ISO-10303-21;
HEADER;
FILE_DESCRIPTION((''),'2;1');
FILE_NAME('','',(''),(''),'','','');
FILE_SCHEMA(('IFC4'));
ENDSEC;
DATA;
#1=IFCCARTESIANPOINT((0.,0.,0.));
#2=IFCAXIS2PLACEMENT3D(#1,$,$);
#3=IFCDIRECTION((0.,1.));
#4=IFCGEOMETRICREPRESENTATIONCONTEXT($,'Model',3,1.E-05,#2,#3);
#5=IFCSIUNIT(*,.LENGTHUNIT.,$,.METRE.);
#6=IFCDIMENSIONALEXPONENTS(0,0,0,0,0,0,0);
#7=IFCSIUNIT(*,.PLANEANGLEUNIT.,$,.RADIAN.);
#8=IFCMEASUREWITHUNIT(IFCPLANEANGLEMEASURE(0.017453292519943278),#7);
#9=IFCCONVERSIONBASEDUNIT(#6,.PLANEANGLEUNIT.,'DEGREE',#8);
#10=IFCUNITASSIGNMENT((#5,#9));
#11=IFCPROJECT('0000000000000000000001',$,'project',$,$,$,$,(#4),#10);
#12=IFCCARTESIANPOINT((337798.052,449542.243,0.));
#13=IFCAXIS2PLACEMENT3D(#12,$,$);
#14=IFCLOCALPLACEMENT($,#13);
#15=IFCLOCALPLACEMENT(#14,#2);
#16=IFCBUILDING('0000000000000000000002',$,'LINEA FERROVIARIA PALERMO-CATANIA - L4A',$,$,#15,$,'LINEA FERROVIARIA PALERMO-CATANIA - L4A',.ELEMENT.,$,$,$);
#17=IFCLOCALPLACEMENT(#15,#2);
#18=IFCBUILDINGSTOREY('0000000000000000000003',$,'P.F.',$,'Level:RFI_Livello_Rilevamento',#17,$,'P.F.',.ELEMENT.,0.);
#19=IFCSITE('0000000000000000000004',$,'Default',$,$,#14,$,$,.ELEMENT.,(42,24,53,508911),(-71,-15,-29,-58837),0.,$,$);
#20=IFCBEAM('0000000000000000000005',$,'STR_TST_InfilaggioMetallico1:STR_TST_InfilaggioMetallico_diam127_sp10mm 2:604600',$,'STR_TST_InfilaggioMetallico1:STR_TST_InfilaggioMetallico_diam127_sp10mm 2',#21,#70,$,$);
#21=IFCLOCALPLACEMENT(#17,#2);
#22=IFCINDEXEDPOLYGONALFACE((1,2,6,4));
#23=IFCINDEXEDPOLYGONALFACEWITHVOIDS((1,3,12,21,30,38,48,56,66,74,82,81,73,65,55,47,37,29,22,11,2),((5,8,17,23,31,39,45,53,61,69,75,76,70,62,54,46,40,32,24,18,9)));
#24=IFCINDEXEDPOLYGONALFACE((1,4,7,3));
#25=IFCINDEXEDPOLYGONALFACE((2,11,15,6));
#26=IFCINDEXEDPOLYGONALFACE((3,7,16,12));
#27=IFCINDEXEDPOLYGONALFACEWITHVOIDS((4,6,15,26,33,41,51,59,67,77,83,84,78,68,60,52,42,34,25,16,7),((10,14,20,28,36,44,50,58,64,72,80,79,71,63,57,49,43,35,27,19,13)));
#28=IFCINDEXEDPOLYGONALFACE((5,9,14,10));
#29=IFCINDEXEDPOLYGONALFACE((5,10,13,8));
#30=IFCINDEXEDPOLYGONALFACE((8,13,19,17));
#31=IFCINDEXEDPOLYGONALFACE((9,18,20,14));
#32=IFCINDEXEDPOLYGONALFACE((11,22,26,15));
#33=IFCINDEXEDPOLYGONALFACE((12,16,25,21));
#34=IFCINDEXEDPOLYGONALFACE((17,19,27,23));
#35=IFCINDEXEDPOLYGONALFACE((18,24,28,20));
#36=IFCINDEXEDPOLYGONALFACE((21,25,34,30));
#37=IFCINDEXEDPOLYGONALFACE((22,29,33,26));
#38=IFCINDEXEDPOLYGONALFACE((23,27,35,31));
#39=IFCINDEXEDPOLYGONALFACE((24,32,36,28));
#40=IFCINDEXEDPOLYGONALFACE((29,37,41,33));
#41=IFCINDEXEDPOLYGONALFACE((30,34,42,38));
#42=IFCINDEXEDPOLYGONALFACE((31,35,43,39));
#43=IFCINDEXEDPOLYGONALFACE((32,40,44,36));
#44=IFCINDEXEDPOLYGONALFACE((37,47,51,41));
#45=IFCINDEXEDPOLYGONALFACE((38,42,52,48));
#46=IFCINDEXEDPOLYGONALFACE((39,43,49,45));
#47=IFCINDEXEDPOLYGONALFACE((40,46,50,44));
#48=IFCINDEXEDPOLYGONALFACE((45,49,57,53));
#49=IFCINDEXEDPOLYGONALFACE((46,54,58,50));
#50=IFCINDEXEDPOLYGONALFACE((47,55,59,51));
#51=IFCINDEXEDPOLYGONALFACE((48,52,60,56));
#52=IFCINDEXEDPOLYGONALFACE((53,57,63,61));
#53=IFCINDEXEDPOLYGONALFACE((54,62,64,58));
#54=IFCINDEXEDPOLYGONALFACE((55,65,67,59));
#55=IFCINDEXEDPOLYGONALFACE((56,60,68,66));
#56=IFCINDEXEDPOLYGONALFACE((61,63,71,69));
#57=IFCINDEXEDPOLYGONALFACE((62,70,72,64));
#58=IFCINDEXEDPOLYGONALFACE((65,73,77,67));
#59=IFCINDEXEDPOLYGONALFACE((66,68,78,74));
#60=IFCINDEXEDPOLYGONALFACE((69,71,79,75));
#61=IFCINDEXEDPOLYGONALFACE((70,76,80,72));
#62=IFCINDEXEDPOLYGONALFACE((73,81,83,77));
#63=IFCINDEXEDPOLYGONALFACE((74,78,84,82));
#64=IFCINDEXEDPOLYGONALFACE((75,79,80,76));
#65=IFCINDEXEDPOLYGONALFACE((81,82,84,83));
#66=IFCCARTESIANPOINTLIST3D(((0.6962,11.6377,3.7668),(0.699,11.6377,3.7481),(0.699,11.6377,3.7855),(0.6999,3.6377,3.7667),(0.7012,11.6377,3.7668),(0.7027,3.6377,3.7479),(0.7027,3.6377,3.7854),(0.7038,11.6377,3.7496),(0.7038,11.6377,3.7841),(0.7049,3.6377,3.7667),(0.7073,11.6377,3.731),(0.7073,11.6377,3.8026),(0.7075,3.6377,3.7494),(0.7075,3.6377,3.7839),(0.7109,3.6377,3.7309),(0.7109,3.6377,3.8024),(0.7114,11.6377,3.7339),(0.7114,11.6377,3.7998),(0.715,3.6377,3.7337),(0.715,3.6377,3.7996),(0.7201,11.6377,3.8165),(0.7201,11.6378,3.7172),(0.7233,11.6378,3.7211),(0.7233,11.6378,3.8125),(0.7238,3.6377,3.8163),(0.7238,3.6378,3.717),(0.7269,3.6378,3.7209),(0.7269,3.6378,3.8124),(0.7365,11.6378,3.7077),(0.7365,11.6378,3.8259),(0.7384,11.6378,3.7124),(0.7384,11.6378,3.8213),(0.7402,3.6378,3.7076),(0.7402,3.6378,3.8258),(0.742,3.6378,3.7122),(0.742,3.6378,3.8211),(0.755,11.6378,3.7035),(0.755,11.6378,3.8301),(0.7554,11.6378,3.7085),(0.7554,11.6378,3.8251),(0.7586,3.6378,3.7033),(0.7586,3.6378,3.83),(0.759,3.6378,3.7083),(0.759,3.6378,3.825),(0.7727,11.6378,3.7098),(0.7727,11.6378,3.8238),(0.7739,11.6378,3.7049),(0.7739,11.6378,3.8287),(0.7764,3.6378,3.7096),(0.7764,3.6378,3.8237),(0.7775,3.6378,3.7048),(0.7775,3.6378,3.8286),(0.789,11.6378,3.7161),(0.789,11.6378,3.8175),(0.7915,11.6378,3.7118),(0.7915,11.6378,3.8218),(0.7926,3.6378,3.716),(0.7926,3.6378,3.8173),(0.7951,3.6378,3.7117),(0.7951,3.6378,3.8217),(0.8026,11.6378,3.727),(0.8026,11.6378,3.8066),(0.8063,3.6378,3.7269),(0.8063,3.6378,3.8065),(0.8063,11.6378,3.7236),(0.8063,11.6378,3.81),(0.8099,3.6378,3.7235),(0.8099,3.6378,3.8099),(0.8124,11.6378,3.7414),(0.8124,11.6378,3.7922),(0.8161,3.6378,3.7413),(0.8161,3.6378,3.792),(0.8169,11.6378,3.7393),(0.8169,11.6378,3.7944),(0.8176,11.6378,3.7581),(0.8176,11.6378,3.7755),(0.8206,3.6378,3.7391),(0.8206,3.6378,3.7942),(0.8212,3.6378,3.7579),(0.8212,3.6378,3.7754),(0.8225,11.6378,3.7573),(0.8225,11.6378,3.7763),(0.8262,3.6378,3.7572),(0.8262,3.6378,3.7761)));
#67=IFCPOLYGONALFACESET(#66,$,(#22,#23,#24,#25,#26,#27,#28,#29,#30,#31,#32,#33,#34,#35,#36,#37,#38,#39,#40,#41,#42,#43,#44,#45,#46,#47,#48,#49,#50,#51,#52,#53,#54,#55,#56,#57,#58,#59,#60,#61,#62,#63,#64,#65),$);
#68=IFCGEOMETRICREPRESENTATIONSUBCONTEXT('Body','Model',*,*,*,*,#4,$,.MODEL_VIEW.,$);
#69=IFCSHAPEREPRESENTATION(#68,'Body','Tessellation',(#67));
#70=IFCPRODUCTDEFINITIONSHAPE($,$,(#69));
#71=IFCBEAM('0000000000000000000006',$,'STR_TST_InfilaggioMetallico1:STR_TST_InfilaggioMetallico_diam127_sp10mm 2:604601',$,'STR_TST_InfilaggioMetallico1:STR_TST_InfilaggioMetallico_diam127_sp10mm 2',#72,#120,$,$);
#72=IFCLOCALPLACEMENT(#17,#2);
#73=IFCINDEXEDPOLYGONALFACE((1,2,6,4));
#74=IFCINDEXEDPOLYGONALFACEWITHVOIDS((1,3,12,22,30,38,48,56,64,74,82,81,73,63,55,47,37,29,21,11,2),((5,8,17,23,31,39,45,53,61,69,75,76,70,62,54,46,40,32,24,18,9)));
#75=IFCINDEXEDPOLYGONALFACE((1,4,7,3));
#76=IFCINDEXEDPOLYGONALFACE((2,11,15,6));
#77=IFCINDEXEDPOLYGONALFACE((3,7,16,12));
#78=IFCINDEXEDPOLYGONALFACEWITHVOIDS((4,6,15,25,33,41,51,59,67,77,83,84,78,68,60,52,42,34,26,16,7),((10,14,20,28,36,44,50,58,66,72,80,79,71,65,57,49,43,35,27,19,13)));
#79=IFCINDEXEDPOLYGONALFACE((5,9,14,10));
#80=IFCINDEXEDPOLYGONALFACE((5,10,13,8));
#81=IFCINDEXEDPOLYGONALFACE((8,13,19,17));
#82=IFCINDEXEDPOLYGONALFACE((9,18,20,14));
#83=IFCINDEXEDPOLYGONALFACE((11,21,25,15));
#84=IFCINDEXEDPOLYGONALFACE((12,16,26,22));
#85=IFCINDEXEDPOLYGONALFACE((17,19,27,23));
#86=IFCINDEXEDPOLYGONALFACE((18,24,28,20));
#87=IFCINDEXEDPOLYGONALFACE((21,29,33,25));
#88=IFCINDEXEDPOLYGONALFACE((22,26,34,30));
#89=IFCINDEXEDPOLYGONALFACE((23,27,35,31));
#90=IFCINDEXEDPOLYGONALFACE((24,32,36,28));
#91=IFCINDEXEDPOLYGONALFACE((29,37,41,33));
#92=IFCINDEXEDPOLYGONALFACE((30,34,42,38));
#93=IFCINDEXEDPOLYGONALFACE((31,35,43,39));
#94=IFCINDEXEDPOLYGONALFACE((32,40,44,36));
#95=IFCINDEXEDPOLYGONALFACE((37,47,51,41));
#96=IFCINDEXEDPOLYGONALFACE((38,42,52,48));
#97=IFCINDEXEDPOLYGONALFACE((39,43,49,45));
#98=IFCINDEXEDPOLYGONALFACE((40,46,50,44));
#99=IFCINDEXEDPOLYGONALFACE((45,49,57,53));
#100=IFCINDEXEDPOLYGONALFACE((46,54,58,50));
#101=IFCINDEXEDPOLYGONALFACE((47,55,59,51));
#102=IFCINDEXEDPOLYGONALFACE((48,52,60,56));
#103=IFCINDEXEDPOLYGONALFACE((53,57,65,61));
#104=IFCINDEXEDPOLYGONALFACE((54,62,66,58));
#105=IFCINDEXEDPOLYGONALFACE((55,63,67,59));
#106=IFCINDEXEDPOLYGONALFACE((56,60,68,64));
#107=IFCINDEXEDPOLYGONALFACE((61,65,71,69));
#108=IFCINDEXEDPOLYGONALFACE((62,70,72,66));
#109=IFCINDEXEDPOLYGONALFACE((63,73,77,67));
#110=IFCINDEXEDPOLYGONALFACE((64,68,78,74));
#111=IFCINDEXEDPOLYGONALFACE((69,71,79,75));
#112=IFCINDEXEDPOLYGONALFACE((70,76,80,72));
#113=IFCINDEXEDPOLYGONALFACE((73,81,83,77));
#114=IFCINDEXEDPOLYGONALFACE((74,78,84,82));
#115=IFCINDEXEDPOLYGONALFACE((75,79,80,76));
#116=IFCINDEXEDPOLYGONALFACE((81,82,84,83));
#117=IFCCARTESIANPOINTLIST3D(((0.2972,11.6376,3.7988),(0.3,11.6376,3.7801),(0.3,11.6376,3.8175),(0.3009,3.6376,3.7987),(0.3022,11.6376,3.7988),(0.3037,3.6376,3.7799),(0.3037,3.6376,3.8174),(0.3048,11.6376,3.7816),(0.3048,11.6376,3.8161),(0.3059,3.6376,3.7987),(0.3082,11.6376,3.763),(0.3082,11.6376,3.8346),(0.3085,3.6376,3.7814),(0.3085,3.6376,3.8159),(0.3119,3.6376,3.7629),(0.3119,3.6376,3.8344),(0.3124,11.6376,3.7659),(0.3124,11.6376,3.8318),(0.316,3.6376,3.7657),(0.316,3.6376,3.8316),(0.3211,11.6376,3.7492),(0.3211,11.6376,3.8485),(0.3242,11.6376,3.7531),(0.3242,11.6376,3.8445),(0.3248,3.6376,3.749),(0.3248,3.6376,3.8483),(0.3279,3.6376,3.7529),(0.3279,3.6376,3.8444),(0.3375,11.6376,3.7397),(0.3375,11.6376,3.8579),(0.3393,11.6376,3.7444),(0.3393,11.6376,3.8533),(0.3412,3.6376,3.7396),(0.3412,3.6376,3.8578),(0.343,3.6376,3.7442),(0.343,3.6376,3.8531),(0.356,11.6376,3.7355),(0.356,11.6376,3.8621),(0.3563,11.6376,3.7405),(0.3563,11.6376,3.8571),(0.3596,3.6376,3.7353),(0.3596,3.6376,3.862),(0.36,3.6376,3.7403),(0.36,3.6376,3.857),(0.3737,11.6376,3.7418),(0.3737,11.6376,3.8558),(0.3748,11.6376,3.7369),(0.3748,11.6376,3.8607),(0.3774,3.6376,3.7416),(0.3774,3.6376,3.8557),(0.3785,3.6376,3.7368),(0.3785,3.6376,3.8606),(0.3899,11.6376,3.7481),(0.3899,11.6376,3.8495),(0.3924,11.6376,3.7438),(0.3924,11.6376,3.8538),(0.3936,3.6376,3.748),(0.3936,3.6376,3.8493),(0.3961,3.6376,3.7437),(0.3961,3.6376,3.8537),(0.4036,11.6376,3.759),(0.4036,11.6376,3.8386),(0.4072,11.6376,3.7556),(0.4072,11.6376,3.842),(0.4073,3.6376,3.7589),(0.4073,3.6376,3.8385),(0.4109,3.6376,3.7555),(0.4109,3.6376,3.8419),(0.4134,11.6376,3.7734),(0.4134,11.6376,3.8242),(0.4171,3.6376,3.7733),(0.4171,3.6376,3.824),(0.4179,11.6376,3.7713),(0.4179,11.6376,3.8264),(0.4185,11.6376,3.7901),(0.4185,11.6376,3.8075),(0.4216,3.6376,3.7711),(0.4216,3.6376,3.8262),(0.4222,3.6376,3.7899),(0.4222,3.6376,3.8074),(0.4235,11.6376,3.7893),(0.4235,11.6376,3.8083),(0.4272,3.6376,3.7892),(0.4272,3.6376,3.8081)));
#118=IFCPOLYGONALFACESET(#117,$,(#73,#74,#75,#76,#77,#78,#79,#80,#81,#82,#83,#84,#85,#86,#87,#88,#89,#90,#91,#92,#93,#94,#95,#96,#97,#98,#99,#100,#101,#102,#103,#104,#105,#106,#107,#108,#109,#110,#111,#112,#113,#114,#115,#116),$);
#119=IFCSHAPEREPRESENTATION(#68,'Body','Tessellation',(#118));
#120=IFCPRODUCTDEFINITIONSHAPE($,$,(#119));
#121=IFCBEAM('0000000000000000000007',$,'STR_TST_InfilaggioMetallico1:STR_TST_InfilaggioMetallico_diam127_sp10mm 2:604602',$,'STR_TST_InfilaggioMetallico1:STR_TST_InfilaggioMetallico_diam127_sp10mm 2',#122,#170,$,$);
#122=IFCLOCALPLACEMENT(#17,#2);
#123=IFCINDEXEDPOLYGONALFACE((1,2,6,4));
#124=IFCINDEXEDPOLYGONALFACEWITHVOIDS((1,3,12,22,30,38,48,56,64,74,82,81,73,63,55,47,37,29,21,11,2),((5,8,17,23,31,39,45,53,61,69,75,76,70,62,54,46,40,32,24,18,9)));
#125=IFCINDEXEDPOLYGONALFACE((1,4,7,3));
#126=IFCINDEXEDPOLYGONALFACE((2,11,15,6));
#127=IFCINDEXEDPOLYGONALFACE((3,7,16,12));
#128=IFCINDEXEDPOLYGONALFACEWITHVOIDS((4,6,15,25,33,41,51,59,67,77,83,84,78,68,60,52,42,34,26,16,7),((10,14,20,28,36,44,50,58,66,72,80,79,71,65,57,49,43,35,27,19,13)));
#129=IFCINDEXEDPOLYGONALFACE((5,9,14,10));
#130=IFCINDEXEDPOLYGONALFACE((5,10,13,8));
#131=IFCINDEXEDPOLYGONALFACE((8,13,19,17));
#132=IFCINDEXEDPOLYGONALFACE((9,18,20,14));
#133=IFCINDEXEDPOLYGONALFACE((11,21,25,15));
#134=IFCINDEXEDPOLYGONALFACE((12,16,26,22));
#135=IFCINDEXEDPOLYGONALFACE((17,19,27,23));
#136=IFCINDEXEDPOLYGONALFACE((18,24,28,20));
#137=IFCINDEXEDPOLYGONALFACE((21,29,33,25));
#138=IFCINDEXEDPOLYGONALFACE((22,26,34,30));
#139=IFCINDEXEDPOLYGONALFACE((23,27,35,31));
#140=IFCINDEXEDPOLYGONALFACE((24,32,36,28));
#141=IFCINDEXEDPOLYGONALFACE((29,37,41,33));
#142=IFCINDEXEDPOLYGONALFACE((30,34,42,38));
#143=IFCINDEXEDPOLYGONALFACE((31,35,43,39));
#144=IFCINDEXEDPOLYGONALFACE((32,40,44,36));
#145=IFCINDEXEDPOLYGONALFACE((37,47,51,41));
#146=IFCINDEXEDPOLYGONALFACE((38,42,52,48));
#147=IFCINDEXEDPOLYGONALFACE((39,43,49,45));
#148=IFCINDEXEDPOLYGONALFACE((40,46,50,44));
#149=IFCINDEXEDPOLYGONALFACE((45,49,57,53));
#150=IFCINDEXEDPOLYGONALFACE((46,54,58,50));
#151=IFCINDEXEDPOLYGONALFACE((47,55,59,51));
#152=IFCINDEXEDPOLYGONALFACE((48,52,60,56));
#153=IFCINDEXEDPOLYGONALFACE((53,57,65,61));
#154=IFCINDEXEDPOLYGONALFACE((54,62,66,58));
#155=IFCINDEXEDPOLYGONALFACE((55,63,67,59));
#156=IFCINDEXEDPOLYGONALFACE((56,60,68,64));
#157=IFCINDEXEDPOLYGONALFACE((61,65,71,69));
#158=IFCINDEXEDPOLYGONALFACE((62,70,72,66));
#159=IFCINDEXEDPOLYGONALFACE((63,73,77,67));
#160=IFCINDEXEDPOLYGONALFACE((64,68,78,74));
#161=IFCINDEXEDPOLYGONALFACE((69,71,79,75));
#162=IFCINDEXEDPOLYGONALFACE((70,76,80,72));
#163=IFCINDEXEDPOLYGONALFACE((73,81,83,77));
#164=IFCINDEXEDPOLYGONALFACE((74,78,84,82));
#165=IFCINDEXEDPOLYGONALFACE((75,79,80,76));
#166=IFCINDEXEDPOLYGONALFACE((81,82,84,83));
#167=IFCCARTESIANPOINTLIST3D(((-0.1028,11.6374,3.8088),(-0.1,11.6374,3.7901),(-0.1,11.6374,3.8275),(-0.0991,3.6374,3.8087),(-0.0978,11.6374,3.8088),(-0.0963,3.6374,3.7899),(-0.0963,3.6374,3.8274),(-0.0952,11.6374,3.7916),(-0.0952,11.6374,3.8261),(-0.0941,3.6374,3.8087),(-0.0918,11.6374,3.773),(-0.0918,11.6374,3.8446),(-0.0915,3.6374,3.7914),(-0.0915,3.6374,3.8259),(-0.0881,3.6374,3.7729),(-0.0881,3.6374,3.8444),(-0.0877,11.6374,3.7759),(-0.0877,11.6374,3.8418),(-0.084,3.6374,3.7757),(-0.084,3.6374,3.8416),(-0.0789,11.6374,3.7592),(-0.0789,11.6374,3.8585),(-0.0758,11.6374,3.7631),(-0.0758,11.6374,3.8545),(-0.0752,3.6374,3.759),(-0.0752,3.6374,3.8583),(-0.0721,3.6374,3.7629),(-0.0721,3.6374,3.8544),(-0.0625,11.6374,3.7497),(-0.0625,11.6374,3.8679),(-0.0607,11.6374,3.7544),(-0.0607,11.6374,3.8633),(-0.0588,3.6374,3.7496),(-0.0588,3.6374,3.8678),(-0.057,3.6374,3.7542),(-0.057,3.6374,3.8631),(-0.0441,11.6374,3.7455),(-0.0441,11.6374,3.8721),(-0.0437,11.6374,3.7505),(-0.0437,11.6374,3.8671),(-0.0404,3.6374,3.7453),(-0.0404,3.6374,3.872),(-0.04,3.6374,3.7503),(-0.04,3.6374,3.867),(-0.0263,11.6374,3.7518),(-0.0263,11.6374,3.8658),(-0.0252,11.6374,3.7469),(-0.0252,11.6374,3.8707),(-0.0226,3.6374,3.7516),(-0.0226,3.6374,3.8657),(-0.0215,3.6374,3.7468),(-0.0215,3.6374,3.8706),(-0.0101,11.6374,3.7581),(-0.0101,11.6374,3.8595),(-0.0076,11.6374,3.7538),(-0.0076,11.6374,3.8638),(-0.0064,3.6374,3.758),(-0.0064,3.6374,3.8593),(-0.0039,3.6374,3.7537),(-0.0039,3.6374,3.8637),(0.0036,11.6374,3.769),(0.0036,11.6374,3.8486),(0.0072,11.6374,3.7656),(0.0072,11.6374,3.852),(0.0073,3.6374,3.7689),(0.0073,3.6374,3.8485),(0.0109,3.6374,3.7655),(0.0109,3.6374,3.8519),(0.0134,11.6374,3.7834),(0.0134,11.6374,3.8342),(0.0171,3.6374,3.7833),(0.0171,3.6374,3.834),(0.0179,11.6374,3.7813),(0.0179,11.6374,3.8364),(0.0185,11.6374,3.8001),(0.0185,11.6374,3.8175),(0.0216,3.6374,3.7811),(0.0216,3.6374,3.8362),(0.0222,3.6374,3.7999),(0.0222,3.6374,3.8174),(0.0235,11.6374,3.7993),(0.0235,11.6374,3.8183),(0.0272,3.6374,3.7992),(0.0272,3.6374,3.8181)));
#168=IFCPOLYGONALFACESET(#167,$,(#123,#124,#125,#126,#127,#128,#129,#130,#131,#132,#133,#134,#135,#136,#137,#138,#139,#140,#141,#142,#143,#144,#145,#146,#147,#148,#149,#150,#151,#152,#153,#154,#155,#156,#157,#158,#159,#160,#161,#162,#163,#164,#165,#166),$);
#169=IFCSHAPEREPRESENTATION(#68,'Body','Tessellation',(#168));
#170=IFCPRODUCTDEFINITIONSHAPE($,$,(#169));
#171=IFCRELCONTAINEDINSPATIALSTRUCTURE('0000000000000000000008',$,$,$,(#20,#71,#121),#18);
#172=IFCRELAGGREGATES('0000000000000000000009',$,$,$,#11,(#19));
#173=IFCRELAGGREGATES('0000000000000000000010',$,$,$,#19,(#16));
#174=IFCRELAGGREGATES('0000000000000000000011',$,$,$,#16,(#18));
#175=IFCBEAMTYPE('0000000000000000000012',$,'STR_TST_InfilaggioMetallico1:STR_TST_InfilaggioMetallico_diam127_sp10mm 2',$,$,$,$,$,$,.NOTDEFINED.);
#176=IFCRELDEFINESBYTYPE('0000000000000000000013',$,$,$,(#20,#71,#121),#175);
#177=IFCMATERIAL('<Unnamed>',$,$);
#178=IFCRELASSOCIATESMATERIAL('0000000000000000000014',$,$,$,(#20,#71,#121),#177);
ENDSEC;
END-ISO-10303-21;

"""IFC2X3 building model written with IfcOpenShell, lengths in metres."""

from ifc_helpers import new_model, entity, si_unit, converted_unit, direction, frame, origin, origin_2d_with_axis, place, context, subcontext, project, spatial, hollow_circle, extrude, material, type_object, element, save


model = new_model("IFC2X3")

# Units and contexts
model_context = context("Model", 3, precision=1e-05, world=origin(), true_north=direction((0.0, 1.0)))
body_context = subcontext(model_context, "Body", "Model", "MODEL_VIEW")
ifc_project = project(units=[si_unit("LENGTHUNIT", "METRE"), converted_unit("PLANEANGLEUNIT", "DEGREE", entity("IfcPlaneAngleMeasure", 0.017453292519943278), si_unit("PLANEANGLEUNIT", "RADIAN"), dimensions=[0, 0, 0, 0, 0, 0, 0])], contexts=[model_context])

# Site, building, storey
site_placement = place(None, frame((337798.052, 449542.243, 0.0)))
site = spatial("IfcSite", under=ifc_project, at=site_placement, Name="Default", CompositionType="ELEMENT", RefLatitude=(42, 24, 53, 508911), RefLongitude=(-71, -15, -29, -58837), RefElevation=0.0)
building_placement = place(site_placement, origin())
building = spatial("IfcBuilding", under=site, at=building_placement, Name="LINEA FERROVIARIA PALERMO-CATANIA - L4A", LongName="LINEA FERROVIARIA PALERMO-CATANIA - L4A", CompositionType="ELEMENT")
storey_placement = place(building_placement, origin())
storey = spatial("IfcBuildingStorey", under=building, at=storey_placement, Name="P.F.", ObjectType="Level:RFI_Livello_Rilevamento", LongName="P.F.", CompositionType="ELEMENT", Elevation=0.0)

# Beams
ifc_material = material(Name="<Unnamed>")
beam_type = type_object("IfcBeamType", Name="STR_TST_InfilaggioMetallico1:STR_TST_InfilaggioMetallico_diam127_sp10mm 2", PredefinedType="NOTDEFINED")
beam_1_placement = place(storey_placement, frame((0.6946, 3.6377, 3.8319), z_axis=(0.0, -0.000018, 1.0), x_axis=(-0.000456, 1.0, 0.000018)))
element("IfcBeam", 1, at=beam_1_placement, inside=storey, type_object=beam_type, material=ifc_material, Name="STR_TST_InfilaggioMetallico1:STR_TST_InfilaggioMetallico_diam127_sp10mm 2:604600", ObjectType="STR_TST_InfilaggioMetallico1:STR_TST_InfilaggioMetallico_diam127_sp10mm 2", context=body_context, shape_type="SweptSolid", body=[
    extrude(hollow_circle(Radius=0.0635, WallThickness=0.005, at=origin_2d_with_axis()), frame((0.0, -0.0687, -0.0652), z_axis=(1.0, 0.0, 0.0), x_axis=(0.0, 1.0, 0.0)), (0.0, 0.0, 1.0), 8.0),
])
beam_2_placement = place(storey_placement, frame((0.2956, 3.6376, 3.8639), z_axis=(0.0, -0.000019, 1.0), x_axis=(-0.00046, 1.0, 0.000019)))
element("IfcBeam", 2, at=beam_2_placement, inside=storey, type_object=beam_type, material=ifc_material, Name="STR_TST_InfilaggioMetallico1:STR_TST_InfilaggioMetallico_diam127_sp10mm 2:604601", ObjectType="STR_TST_InfilaggioMetallico1:STR_TST_InfilaggioMetallico_diam127_sp10mm 2", context=body_context, shape_type="SweptSolid", body=[
    extrude(hollow_circle(Radius=0.0635, WallThickness=0.005, at=origin_2d_with_axis()), frame((0.0, -0.0688, -0.0652), z_axis=(1.0, 0.0, 0.0), x_axis=(0.0, 1.0, 0.0)), (0.0, 0.0, 1.0), 8.0),
])
beam_3_placement = place(storey_placement, frame((-0.1044, 3.6374, 3.8739), z_axis=(0.0, -0.000019, 1.0), x_axis=(-0.000463, 1.0, 0.000019)))
element("IfcBeam", 3, at=beam_3_placement, inside=storey, type_object=beam_type, material=ifc_material, Name="STR_TST_InfilaggioMetallico1:STR_TST_InfilaggioMetallico_diam127_sp10mm 2:604602", ObjectType="STR_TST_InfilaggioMetallico1:STR_TST_InfilaggioMetallico_diam127_sp10mm 2", context=body_context, shape_type="SweptSolid", body=[
    extrude(hollow_circle(Radius=0.0635, WallThickness=0.005, at=origin_2d_with_axis()), frame((0.0, -0.0688, -0.0652), z_axis=(1.0, 0.0, 0.0), x_axis=(0.0, 1.0, 0.0)), (0.0, 0.0, 1.0), 8.0),
])

save(model, "model.ifc")
